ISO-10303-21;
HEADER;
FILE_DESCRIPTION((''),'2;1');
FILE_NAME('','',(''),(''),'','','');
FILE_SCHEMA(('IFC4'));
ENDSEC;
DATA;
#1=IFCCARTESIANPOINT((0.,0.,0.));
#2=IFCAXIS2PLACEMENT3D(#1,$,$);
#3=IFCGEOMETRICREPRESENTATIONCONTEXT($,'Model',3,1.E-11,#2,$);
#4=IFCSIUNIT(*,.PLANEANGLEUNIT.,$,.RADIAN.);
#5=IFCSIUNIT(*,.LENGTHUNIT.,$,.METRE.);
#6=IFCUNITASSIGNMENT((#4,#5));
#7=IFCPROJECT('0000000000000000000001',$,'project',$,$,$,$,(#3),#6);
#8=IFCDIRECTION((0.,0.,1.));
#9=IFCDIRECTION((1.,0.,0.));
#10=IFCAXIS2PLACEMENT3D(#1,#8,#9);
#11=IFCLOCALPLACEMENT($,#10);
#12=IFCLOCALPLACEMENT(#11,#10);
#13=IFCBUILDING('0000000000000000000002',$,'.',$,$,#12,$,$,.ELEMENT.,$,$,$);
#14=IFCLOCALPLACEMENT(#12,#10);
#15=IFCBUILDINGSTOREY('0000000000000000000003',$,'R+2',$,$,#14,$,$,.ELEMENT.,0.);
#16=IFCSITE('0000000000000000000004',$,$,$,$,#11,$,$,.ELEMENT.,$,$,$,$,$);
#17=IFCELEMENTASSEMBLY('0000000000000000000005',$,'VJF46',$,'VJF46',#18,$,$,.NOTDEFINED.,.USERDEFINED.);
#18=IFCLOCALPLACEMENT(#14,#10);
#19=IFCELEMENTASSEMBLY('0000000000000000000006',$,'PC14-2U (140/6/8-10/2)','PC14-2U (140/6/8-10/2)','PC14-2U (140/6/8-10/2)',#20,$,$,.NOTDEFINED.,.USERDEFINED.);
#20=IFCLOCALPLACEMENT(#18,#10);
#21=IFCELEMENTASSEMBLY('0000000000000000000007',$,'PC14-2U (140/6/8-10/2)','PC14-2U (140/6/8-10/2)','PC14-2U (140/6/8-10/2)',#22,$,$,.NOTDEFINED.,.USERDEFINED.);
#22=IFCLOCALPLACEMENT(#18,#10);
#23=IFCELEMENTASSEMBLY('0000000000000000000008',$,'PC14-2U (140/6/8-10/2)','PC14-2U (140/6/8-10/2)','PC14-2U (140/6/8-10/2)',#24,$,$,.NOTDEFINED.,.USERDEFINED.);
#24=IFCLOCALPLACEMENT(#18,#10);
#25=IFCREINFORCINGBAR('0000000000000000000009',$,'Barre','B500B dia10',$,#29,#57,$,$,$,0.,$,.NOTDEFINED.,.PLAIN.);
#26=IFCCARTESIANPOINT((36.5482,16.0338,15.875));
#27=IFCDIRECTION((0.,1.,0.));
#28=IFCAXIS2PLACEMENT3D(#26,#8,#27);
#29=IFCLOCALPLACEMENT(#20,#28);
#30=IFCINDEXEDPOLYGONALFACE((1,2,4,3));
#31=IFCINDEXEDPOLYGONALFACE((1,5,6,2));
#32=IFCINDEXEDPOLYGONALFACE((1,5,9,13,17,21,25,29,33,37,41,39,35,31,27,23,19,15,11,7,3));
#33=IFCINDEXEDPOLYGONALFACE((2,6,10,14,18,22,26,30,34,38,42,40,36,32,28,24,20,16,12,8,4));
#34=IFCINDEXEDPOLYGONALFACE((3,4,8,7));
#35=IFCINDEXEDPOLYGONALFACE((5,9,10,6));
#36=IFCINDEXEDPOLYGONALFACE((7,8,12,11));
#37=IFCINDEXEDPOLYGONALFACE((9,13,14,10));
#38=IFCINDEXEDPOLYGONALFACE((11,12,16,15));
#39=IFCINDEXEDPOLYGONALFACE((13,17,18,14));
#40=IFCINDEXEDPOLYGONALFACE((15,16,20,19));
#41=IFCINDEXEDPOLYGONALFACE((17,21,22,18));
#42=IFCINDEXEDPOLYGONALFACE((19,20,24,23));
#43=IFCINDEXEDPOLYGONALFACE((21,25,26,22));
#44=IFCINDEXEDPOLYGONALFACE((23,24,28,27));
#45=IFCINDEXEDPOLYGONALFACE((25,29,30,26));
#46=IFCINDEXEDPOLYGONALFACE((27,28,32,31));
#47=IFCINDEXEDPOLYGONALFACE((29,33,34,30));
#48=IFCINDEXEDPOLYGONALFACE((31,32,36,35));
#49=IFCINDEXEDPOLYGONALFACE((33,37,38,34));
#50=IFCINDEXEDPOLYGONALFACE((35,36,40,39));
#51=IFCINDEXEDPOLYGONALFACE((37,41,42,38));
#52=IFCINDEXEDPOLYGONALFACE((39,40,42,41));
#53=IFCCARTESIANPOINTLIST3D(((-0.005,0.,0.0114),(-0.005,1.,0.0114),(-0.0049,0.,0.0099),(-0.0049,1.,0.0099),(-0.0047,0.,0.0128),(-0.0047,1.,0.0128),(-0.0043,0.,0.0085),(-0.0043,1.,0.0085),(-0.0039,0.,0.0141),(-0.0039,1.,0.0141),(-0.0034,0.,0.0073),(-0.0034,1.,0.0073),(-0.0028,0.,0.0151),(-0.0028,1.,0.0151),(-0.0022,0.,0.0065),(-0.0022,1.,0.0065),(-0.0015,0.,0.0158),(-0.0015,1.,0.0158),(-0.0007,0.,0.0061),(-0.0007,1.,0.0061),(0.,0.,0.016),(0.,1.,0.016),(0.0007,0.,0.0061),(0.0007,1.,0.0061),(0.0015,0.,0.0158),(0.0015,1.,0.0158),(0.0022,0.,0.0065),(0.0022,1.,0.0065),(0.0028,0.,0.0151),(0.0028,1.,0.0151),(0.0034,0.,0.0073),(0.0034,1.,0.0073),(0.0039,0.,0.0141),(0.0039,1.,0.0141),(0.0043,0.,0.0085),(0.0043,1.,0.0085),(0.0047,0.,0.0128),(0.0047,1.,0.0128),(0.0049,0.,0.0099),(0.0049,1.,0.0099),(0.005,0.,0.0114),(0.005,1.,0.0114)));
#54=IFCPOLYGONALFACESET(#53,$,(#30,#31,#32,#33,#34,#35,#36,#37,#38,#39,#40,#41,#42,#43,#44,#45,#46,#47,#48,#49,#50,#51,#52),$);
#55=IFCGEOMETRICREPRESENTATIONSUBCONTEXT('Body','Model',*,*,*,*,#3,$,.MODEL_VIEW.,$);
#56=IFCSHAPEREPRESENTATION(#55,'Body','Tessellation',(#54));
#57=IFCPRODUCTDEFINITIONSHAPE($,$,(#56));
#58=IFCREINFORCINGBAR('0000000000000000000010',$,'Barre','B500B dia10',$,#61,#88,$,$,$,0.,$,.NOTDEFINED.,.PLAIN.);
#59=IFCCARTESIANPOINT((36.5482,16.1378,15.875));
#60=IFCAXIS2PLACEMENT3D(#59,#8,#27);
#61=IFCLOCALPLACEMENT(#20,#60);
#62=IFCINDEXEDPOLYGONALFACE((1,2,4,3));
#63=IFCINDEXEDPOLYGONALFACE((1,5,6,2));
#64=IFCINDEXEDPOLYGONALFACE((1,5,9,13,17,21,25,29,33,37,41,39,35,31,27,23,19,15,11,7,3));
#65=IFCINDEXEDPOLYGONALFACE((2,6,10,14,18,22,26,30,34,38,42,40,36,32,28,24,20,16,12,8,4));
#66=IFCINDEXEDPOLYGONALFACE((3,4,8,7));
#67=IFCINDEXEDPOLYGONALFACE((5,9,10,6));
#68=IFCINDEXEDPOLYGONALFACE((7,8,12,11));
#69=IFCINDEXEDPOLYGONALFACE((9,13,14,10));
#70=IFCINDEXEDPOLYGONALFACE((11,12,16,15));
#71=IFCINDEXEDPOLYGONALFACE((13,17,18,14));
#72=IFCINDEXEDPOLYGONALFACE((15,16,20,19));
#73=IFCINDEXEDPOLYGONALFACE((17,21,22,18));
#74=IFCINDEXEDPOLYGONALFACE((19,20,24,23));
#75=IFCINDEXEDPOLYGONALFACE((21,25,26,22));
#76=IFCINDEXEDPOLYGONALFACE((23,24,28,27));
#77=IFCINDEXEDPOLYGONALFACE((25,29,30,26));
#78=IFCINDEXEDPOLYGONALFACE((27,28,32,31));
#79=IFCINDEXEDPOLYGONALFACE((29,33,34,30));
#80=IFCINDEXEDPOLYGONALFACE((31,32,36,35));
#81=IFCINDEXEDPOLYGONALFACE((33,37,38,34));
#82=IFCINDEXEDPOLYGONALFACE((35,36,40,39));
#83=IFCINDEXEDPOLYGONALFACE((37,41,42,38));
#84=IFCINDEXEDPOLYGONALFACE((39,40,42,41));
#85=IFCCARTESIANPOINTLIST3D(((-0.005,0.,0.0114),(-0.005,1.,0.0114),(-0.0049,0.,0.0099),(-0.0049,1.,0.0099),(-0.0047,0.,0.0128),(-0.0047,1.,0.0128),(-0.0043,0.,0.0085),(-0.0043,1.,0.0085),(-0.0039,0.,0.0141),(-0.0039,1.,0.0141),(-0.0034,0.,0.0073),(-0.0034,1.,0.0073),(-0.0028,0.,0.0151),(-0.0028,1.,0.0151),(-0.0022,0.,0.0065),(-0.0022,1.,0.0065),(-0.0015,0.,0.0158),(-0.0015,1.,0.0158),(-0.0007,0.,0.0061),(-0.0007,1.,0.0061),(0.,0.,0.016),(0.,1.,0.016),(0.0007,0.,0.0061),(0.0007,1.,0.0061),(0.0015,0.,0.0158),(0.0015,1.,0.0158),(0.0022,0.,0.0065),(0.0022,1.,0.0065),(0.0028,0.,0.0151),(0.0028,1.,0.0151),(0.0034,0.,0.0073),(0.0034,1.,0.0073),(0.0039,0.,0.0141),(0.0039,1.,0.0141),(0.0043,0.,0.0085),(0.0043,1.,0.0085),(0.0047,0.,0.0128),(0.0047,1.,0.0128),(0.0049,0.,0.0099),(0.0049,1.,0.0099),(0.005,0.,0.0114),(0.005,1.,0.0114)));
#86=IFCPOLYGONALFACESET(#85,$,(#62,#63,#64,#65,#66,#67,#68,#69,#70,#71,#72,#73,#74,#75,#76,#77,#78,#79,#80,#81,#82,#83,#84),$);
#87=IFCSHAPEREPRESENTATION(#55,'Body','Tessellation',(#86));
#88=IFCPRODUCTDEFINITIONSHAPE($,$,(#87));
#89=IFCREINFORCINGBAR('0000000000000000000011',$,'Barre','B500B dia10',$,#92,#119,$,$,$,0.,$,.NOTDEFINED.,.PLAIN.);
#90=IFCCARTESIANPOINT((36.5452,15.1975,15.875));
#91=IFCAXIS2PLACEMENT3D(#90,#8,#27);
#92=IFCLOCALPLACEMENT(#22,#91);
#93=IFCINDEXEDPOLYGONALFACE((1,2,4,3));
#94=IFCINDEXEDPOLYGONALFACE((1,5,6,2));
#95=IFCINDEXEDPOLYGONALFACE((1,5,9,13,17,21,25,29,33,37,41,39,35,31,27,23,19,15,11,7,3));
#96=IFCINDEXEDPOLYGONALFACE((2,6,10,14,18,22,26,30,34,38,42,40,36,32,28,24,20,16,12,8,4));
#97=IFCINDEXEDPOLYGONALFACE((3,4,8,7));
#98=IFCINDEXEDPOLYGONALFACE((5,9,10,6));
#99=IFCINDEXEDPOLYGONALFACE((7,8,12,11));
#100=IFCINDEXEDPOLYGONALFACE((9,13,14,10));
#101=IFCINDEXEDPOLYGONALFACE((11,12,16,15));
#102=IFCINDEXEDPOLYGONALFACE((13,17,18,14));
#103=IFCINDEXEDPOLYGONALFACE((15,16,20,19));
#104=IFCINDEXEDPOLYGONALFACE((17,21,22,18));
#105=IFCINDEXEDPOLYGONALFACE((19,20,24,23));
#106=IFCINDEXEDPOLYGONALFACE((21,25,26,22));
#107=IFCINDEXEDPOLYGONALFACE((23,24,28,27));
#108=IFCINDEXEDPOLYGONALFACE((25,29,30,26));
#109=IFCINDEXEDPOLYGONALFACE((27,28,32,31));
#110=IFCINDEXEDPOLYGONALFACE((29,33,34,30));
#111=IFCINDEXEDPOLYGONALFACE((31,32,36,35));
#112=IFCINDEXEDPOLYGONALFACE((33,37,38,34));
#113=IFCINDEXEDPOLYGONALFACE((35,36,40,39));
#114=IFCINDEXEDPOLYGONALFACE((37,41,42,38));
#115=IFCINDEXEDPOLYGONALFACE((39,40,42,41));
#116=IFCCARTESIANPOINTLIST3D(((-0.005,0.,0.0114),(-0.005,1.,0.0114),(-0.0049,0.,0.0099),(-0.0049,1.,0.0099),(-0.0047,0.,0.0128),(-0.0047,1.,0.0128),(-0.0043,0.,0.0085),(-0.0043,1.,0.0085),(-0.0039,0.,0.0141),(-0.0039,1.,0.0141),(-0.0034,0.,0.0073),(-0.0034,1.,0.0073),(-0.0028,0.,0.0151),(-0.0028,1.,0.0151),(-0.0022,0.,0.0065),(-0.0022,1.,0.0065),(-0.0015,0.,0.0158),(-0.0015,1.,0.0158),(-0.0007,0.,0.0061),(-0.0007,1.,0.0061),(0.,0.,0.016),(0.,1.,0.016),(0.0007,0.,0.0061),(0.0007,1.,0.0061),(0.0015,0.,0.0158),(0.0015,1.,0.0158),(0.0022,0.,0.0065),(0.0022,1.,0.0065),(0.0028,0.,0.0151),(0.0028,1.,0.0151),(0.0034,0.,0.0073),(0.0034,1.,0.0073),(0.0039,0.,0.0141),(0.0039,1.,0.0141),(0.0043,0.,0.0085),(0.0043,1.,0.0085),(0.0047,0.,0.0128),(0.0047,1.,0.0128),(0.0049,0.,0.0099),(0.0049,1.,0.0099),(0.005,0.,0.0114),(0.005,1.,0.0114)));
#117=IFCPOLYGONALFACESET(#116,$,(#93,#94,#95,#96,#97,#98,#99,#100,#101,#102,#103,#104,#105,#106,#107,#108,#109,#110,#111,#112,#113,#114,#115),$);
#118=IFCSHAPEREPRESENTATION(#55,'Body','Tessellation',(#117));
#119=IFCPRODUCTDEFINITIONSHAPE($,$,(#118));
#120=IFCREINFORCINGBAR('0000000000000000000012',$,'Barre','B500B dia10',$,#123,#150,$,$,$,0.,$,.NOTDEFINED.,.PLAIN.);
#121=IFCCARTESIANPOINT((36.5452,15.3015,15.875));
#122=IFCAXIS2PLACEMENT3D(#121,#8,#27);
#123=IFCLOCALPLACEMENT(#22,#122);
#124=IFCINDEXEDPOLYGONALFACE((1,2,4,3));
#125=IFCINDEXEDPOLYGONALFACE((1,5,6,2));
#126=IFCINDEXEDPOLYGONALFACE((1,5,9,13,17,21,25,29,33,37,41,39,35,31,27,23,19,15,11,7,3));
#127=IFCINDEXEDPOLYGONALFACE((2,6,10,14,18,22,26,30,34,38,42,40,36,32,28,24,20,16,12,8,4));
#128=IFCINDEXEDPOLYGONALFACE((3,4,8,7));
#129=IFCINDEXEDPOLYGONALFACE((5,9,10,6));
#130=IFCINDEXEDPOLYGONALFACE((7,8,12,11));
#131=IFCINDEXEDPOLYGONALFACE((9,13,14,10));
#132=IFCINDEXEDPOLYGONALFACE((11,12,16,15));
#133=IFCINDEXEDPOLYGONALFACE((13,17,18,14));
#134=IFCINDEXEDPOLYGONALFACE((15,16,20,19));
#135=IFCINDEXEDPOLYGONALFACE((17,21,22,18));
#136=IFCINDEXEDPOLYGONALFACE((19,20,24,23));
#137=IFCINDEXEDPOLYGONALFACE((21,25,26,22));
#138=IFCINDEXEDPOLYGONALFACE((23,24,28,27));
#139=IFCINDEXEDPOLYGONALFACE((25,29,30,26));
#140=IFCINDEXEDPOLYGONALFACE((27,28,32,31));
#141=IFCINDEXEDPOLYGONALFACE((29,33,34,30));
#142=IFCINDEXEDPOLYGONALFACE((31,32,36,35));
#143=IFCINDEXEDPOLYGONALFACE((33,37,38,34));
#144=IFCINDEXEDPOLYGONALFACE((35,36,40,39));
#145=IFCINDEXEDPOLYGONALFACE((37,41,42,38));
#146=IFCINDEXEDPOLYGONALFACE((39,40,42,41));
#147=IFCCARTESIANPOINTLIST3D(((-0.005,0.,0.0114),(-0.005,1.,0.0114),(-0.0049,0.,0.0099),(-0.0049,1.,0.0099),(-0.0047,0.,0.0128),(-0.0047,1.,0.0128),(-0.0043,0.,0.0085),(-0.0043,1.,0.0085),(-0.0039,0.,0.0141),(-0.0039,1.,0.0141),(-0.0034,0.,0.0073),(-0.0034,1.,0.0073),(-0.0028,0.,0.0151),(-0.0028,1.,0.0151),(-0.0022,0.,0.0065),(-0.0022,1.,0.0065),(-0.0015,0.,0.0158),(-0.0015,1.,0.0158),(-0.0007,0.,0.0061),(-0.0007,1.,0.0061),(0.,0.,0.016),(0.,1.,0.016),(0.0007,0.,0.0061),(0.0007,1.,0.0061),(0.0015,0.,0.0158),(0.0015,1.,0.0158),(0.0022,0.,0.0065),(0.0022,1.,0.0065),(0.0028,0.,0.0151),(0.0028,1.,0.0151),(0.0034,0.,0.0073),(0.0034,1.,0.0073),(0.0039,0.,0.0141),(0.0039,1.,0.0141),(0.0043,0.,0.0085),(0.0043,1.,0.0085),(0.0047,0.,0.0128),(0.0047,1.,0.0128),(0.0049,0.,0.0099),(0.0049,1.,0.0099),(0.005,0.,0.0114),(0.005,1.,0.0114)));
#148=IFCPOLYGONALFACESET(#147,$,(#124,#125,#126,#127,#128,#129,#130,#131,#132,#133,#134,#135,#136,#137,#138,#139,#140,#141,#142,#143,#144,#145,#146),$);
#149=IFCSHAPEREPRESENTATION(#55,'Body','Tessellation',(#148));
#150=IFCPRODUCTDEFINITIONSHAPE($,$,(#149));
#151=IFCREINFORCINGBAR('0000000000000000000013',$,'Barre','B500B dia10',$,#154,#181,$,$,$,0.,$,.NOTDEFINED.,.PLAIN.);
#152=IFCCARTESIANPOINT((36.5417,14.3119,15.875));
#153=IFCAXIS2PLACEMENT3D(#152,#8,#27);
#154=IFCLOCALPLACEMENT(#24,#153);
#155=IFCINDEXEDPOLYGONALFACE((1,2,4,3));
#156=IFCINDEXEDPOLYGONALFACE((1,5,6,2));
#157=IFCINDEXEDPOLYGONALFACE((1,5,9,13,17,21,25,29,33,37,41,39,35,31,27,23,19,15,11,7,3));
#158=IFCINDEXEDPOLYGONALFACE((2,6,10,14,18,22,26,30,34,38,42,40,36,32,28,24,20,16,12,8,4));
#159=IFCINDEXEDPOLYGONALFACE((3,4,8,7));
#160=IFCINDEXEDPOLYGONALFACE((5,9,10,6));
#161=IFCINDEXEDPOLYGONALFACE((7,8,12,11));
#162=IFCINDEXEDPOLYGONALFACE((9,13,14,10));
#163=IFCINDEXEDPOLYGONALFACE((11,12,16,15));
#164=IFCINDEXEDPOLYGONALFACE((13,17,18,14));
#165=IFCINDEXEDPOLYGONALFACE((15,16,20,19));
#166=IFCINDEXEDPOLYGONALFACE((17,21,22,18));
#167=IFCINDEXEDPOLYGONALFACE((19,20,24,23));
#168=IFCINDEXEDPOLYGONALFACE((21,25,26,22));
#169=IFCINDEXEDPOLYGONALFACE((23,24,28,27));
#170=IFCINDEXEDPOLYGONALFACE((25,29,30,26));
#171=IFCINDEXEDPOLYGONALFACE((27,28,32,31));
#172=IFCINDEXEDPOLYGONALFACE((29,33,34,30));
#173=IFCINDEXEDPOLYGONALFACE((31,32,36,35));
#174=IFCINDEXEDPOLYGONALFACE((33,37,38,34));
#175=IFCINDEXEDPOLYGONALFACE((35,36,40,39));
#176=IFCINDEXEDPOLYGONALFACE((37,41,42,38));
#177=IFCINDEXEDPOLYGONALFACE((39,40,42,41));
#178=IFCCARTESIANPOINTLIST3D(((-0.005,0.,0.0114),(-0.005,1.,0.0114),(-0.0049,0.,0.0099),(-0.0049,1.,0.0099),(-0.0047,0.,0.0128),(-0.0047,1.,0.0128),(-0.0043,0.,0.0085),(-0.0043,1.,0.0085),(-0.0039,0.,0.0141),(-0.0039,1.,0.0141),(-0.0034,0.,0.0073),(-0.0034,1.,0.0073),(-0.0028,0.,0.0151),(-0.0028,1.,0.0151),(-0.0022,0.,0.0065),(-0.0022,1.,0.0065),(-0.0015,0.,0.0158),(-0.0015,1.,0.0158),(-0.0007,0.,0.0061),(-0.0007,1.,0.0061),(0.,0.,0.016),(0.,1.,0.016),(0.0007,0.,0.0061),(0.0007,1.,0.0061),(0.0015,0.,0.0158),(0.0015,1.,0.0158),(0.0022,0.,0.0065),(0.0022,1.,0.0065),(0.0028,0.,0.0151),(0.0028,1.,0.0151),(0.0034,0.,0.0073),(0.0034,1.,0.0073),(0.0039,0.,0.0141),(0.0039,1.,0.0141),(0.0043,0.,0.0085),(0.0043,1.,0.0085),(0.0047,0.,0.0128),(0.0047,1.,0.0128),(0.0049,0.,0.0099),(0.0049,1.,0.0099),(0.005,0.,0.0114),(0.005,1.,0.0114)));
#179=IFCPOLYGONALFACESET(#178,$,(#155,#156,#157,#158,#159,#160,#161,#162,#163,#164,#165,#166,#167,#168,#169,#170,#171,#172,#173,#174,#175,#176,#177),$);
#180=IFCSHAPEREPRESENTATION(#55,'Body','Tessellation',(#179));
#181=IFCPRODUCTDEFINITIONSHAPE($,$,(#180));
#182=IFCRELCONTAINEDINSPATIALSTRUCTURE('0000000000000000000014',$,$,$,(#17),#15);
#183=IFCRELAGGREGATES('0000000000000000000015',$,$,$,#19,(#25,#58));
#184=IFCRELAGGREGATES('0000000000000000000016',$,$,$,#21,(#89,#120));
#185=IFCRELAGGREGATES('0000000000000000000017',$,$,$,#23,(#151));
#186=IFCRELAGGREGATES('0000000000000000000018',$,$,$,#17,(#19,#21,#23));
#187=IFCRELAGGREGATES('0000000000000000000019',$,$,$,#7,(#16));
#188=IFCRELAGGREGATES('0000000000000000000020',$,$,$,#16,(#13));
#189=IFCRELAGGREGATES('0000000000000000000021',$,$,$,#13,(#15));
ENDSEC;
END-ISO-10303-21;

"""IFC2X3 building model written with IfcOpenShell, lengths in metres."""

from ifc_helpers import new_model, entity, si_unit, frame, origin, origin_with_axes, place, context, subcontext, project, spatial, source, transform, mapped, element, aggregate, save


model = new_model("IFC2X3")

# Units and contexts
model_context = context("Model", 3, precision=1e-11, world=origin())
body_context = subcontext(model_context, "Body", "Model", "MODEL_VIEW")
ifc_project = project(units=[si_unit("PLANEANGLEUNIT", "RADIAN"), si_unit("LENGTHUNIT", "METRE")], contexts=[model_context])

# Site, building, storey
site_placement = place(None, origin_with_axes())
site = spatial("IfcSite", under=ifc_project, at=site_placement, CompositionType="ELEMENT")
building_placement = place(site_placement, origin_with_axes())
building = spatial("IfcBuilding", under=site, at=building_placement, Name=".", CompositionType="ELEMENT")
storey_placement = place(building_placement, origin_with_axes())
storey = spatial("IfcBuildingStorey", under=building, at=storey_placement, Name="R+2", CompositionType="ELEMENT", Elevation=0.0)

# Element assemblies, reinforcing bars
assembly_1_placement = place(storey_placement, origin_with_axes())
assembly_1 = element("IfcElementAssembly", 1, at=assembly_1_placement, inside=storey, Name="VJF46", ObjectType="VJF46", AssemblyPlace="NOTDEFINED", PredefinedType="USERDEFINED")
assembly_2_placement = place(assembly_1_placement, origin_with_axes())
assembly_2 = element("IfcElementAssembly", 2, at=assembly_2_placement, Name="PC14-2U (140/6/8-10/2)", Description="PC14-2U (140/6/8-10/2)", ObjectType="PC14-2U (140/6/8-10/2)", AssemblyPlace="NOTDEFINED", PredefinedType="USERDEFINED")
assembly_3_placement = place(assembly_1_placement, origin_with_axes())
assembly_3 = element("IfcElementAssembly", 3, at=assembly_3_placement, Name="PC14-2U (140/6/8-10/2)", Description="PC14-2U (140/6/8-10/2)", ObjectType="PC14-2U (140/6/8-10/2)", AssemblyPlace="NOTDEFINED", PredefinedType="USERDEFINED")
assembly_4_placement = place(assembly_1_placement, origin_with_axes())
assembly_4 = element("IfcElementAssembly", 4, at=assembly_4_placement, Name="PC14-2U (140/6/8-10/2)", Description="PC14-2U (140/6/8-10/2)", ObjectType="PC14-2U (140/6/8-10/2)", AssemblyPlace="NOTDEFINED", PredefinedType="USERDEFINED")
shared_shape_1 = source(origin_with_axes(), body_context, "Body", "AdvancedSweptSolid", [
    entity("IfcSweptDiskSolid", entity("IfcPolyline", [entity("IfcCartesianPoint", [0.0, 0.0, 0.011]), entity("IfcCartesianPoint", [0.0, 1.0, 0.011])]), 0.005, None, 0.0, 1.0),
])
reinforcing_bar_1_placement = place(assembly_2_placement, frame((36.5482, 16.0338, 15.875), z_axis=(0.0, 0.0, 1.0), x_axis=(0.0, 1.0, 0.0)))
reinforcing_bar_1 = element("IfcReinforcingBar", 5, at=reinforcing_bar_1_placement, Name="Barre", Description="B500B dia10", BarRole="NOTDEFINED", BarSurface="PLAIN", CrossSectionArea=0.0, context=body_context, shape_type="MappedRepresentation", body=[
    mapped(shared_shape_1, transform((0.0, 0.0, 0.0), scale=1.0)),
])
reinforcing_bar_2_placement = place(assembly_2_placement, frame((36.5482, 16.1378, 15.875), z_axis=(0.0, 0.0, 1.0), x_axis=(0.0, 1.0, 0.0)))
reinforcing_bar_2 = element("IfcReinforcingBar", 6, at=reinforcing_bar_2_placement, Name="Barre", Description="B500B dia10", BarRole="NOTDEFINED", BarSurface="PLAIN", CrossSectionArea=0.0, context=body_context, shape_type="MappedRepresentation", body=[
    mapped(shared_shape_1, transform((0.0, 0.0, 0.0), scale=1.0)),
])
aggregate(assembly_2, [reinforcing_bar_1, reinforcing_bar_2])
reinforcing_bar_3_placement = place(assembly_3_placement, frame((36.5452, 15.1975, 15.875), z_axis=(0.0, 0.0, 1.0), x_axis=(0.0, 1.0, 0.0)))
reinforcing_bar_3 = element("IfcReinforcingBar", 7, at=reinforcing_bar_3_placement, Name="Barre", Description="B500B dia10", BarRole="NOTDEFINED", BarSurface="PLAIN", CrossSectionArea=0.0, context=body_context, shape_type="MappedRepresentation", body=[
    mapped(shared_shape_1, transform((0.0, 0.0, 0.0), scale=1.0)),
])
reinforcing_bar_4_placement = place(assembly_3_placement, frame((36.5452, 15.3015, 15.875), z_axis=(0.0, 0.0, 1.0), x_axis=(0.0, 1.0, 0.0)))
reinforcing_bar_4 = element("IfcReinforcingBar", 8, at=reinforcing_bar_4_placement, Name="Barre", Description="B500B dia10", BarRole="NOTDEFINED", BarSurface="PLAIN", CrossSectionArea=0.0, context=body_context, shape_type="MappedRepresentation", body=[
    mapped(shared_shape_1, transform((0.0, 0.0, 0.0), scale=1.0)),
])
aggregate(assembly_3, [reinforcing_bar_3, reinforcing_bar_4])
reinforcing_bar_5_placement = place(assembly_4_placement, frame((36.5417, 14.3119, 15.875), z_axis=(0.0, 0.0, 1.0), x_axis=(0.0, 1.0, 0.0)))
reinforcing_bar_5 = element("IfcReinforcingBar", 9, at=reinforcing_bar_5_placement, Name="Barre", Description="B500B dia10", BarRole="NOTDEFINED", BarSurface="PLAIN", CrossSectionArea=0.0, context=body_context, shape_type="MappedRepresentation", body=[
    mapped(shared_shape_1, transform((0.0, 0.0, 0.0), scale=1.0)),
])
aggregate(assembly_4, [reinforcing_bar_5])
aggregate(assembly_1, [assembly_2, assembly_3, assembly_4])

save(model, "model.ifc")
